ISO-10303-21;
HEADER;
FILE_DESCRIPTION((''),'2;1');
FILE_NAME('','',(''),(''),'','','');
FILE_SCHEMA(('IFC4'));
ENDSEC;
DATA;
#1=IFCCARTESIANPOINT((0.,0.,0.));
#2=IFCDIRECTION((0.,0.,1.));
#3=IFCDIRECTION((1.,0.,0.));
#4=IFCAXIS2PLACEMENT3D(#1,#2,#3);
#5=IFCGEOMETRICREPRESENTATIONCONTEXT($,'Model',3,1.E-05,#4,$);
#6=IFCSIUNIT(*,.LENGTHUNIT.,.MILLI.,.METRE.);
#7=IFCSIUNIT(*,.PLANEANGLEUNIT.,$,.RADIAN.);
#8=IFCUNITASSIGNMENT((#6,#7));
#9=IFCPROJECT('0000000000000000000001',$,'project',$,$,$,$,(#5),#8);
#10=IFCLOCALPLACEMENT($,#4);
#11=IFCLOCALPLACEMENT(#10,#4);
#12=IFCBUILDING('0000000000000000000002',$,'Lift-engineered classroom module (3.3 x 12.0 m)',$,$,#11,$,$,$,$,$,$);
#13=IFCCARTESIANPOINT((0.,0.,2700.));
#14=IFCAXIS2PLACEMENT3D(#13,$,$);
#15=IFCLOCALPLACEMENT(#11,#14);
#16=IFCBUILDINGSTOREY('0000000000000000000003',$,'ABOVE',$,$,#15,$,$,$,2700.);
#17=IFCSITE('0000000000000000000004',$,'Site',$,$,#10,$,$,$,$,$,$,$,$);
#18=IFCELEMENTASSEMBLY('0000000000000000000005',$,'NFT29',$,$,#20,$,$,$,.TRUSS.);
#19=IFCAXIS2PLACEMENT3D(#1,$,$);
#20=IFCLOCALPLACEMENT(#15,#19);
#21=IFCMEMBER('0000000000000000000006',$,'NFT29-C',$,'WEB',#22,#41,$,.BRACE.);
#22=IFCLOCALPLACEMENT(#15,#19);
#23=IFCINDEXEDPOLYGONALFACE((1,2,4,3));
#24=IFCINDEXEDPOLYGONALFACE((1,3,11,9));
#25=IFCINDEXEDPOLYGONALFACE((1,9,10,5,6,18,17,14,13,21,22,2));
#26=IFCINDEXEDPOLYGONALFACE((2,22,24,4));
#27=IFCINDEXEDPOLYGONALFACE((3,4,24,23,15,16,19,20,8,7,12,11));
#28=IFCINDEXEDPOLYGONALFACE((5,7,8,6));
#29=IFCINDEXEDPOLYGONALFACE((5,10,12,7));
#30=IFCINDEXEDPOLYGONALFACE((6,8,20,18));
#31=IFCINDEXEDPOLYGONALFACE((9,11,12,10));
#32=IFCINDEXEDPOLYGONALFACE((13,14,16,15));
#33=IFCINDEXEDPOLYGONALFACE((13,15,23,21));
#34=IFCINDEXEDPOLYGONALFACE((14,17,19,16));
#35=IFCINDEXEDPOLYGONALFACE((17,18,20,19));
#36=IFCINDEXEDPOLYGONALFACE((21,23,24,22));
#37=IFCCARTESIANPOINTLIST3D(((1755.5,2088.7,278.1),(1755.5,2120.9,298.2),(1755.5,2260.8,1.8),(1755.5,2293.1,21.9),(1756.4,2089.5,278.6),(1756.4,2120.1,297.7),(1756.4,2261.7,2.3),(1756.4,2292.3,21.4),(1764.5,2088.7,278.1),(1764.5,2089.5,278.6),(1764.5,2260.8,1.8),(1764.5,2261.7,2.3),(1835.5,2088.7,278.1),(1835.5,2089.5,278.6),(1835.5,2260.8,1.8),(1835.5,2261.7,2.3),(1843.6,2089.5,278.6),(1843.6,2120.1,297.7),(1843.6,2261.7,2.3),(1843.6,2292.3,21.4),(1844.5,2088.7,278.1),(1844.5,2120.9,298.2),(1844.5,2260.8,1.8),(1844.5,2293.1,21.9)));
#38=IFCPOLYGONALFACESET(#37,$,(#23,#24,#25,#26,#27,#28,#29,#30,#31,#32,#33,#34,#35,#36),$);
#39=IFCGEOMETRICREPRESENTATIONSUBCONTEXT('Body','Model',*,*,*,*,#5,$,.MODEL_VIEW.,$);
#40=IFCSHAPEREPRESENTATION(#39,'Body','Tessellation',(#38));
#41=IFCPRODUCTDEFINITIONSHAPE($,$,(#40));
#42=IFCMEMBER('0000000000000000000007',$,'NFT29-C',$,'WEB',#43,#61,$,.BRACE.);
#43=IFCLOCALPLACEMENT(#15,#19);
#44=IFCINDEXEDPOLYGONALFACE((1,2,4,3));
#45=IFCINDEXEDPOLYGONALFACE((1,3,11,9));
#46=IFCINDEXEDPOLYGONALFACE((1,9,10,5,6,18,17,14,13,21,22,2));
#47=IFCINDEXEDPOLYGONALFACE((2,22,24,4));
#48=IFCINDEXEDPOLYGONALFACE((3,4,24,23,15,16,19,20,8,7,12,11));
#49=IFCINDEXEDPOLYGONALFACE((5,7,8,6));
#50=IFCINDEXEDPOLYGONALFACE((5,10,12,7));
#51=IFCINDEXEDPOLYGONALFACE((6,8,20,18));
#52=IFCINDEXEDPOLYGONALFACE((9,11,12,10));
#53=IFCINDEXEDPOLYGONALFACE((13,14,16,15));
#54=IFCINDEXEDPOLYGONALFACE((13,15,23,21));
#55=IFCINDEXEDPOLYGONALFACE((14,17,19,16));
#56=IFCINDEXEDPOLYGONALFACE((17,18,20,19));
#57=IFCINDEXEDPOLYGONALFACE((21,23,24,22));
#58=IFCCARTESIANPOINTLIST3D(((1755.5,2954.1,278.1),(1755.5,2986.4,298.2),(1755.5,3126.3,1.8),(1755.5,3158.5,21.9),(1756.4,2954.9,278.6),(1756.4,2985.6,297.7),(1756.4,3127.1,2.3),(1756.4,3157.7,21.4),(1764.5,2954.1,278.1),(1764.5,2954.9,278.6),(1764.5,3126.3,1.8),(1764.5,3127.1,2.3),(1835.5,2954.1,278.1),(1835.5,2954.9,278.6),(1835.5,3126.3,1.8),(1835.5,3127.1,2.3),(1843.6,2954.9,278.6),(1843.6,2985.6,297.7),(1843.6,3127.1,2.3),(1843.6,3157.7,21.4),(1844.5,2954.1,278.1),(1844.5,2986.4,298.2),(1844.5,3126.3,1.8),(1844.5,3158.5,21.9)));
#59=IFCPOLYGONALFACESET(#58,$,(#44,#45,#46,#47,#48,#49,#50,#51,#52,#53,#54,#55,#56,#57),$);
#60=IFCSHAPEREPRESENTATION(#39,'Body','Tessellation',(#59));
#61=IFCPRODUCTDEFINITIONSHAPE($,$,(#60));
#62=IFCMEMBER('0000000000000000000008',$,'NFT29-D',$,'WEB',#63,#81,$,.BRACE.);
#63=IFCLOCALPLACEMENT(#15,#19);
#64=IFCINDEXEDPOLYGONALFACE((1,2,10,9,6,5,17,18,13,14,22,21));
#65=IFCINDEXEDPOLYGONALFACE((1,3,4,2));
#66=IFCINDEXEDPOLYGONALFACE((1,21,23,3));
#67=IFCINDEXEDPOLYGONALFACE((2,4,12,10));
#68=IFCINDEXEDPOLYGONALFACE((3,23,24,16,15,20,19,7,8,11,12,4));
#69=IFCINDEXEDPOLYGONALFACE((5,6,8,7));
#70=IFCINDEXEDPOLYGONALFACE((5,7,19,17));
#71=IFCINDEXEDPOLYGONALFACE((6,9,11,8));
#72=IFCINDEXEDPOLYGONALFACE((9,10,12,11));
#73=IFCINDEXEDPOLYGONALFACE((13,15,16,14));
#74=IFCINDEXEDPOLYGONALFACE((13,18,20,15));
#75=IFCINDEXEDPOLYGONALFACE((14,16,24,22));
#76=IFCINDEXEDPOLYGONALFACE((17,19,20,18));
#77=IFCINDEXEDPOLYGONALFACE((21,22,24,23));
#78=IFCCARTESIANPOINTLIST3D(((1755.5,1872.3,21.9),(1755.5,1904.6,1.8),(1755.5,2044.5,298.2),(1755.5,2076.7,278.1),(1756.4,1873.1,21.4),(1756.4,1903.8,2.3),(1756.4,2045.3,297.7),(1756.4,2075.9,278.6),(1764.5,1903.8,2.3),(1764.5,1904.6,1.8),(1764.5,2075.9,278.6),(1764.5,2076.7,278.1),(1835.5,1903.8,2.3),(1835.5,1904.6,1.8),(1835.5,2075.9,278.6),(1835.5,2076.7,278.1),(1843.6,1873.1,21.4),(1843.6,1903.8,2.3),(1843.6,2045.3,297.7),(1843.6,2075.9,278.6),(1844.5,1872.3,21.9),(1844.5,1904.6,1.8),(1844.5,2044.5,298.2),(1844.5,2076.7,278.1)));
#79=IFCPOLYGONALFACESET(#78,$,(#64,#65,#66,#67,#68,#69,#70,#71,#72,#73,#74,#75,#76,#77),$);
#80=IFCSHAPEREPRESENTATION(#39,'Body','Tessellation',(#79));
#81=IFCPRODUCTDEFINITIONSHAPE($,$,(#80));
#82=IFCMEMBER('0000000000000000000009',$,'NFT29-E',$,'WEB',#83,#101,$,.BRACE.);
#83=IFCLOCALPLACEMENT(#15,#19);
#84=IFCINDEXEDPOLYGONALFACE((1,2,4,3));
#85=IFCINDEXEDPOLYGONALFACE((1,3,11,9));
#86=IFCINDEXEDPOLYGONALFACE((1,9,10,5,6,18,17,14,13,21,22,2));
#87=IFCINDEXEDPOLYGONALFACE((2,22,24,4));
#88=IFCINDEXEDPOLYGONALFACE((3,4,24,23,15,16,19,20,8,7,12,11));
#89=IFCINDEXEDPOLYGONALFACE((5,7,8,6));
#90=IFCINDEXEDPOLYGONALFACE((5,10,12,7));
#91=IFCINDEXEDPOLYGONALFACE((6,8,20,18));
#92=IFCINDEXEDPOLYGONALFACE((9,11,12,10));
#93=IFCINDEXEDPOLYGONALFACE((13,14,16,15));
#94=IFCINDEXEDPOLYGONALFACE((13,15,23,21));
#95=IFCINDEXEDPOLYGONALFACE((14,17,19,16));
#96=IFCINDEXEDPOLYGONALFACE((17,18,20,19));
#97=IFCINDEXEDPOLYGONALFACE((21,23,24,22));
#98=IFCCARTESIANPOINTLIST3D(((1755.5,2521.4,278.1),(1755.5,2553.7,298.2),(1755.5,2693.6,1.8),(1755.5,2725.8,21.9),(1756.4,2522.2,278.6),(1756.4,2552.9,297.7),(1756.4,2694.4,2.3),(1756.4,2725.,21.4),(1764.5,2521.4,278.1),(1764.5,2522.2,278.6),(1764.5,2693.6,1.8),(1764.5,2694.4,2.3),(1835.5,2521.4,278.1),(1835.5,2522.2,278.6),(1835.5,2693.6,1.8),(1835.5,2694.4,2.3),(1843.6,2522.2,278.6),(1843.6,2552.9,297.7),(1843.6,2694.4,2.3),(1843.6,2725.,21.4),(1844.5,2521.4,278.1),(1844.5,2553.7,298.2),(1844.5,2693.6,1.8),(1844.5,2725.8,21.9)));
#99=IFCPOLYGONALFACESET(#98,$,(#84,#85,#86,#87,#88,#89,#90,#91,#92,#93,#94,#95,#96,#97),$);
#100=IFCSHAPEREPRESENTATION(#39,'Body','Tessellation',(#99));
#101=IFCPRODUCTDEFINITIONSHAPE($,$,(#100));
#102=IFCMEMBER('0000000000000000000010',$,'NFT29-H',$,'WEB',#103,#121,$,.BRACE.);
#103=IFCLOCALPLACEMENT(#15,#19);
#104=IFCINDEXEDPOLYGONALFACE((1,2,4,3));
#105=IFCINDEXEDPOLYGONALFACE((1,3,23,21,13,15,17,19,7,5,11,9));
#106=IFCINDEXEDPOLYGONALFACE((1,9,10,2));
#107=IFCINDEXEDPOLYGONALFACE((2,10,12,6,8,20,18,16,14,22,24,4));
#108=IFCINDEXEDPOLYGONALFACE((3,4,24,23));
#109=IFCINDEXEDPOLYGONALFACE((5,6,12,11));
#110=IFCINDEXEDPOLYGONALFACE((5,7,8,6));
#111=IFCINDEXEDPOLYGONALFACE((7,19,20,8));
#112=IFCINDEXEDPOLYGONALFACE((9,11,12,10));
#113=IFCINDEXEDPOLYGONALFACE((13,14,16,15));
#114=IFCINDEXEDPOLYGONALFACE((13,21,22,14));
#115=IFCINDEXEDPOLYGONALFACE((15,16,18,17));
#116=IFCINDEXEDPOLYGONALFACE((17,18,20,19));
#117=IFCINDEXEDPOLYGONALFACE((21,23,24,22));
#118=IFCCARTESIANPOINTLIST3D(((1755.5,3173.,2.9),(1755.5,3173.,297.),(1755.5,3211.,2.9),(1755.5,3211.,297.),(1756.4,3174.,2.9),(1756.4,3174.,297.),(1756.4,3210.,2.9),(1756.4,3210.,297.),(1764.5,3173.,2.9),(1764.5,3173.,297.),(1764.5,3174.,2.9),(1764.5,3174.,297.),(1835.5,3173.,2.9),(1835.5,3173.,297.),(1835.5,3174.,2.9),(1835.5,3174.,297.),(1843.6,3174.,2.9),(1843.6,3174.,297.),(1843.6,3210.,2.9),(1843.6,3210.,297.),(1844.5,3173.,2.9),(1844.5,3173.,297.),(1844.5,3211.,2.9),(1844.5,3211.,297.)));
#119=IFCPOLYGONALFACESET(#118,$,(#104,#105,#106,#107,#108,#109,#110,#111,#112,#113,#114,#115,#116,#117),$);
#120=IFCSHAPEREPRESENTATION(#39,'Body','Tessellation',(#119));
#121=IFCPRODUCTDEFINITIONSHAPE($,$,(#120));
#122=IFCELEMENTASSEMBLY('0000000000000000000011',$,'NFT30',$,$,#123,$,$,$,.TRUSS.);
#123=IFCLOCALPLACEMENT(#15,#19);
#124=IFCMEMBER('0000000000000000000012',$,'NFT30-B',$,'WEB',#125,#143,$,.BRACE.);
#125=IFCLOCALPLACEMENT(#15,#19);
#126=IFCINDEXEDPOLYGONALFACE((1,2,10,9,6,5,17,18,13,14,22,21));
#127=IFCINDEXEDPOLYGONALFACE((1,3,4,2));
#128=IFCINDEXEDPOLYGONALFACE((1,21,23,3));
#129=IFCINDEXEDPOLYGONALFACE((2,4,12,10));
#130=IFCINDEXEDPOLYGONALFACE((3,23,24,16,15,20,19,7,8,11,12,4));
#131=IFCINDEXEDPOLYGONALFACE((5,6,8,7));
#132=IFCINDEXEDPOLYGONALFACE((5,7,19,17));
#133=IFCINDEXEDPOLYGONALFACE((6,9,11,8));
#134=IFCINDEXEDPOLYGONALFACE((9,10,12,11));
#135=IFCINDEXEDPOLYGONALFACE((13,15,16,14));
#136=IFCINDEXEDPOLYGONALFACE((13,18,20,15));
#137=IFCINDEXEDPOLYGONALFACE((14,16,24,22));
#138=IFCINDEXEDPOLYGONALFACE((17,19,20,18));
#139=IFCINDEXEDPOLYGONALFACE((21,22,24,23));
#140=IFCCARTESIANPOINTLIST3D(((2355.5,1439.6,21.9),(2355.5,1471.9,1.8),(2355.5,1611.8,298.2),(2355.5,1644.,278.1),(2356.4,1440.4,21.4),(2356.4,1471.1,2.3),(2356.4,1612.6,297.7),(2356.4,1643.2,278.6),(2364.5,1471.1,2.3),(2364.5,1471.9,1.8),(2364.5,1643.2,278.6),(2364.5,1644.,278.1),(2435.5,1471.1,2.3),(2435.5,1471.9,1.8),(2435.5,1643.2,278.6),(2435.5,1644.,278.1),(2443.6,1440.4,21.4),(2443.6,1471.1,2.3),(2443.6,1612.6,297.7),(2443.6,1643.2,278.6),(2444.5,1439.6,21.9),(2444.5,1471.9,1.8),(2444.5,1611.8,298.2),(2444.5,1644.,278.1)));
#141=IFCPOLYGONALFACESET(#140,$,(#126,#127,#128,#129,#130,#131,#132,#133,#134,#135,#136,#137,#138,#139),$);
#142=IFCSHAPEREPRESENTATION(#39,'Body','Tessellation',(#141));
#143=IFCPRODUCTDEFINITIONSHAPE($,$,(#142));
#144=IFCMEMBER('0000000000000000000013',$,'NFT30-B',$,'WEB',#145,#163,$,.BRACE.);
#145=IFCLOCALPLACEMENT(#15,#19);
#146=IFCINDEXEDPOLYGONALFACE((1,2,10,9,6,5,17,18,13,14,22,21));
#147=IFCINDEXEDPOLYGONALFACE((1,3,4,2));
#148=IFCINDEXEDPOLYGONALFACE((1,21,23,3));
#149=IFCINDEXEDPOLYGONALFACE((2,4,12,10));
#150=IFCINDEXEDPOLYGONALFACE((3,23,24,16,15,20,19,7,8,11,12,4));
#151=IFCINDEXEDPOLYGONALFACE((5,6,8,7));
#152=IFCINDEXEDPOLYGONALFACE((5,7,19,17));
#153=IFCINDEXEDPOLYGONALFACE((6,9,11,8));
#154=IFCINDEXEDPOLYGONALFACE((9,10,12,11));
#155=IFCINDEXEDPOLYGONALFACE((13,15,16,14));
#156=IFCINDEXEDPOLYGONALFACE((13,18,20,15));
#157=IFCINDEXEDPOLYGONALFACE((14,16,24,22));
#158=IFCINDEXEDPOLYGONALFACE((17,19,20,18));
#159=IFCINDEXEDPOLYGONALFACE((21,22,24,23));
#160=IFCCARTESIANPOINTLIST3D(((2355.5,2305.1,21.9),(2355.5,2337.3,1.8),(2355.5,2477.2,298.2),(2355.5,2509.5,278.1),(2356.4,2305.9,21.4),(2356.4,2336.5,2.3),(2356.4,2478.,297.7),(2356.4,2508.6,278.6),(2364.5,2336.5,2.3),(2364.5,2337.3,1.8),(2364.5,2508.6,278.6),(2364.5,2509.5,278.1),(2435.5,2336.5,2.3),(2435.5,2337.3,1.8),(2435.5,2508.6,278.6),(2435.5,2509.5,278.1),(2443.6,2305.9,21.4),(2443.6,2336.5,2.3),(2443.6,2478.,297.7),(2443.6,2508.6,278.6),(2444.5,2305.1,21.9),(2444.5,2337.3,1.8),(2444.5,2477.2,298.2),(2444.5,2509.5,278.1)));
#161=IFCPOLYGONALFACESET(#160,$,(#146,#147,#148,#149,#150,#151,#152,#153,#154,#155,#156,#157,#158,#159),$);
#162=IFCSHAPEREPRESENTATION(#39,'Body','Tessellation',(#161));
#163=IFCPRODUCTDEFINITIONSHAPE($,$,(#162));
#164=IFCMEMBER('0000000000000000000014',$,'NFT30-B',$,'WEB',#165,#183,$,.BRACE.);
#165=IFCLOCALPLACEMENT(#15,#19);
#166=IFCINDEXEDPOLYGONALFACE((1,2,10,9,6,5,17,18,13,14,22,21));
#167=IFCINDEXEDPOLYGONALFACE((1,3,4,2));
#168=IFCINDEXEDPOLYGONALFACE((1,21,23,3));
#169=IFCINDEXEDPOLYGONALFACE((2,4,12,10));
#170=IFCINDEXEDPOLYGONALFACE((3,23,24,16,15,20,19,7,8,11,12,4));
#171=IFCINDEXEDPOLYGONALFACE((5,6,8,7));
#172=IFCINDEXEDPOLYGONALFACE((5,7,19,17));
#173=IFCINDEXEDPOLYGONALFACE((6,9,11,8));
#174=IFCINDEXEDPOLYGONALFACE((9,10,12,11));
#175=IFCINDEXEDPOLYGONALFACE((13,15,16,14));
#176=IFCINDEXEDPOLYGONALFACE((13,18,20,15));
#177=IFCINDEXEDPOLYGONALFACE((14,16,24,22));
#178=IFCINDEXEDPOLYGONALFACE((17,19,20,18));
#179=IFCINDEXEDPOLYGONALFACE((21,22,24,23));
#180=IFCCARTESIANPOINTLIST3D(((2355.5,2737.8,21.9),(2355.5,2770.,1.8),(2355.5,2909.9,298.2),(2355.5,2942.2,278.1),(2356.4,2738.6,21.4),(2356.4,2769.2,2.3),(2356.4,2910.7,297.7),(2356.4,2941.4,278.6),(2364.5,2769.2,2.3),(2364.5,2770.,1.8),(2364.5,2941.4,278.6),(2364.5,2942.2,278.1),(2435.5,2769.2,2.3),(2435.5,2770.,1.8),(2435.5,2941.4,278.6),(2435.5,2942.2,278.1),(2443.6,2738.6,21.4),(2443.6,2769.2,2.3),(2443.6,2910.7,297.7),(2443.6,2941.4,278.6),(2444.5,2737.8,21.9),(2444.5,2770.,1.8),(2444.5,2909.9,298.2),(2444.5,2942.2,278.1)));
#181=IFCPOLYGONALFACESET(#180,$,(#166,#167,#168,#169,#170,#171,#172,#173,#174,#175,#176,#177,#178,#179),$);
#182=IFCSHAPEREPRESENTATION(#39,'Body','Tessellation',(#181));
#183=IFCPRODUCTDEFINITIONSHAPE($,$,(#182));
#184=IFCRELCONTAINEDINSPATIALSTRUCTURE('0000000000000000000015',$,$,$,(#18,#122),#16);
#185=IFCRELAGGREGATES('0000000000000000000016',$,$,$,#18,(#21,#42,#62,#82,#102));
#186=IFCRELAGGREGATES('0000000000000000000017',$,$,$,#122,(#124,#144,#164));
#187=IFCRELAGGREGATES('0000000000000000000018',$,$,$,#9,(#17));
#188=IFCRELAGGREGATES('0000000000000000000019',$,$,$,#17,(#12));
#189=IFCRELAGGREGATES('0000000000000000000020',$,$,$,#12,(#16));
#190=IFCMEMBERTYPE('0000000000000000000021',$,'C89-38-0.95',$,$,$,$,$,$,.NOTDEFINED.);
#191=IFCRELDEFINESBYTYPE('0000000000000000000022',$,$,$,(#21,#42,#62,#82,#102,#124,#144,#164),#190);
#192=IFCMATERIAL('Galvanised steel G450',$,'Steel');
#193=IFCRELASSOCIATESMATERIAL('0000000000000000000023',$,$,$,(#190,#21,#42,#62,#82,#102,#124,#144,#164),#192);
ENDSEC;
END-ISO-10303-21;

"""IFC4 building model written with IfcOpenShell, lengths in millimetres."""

from ifc_helpers import new_model, si_unit, frame, origin, origin_with_axes, origin_2d, place, context, subcontext, project, spatial, c_section, extrude, material, material_profile, profile_set, profile_usage, type_object, element, aggregate, save


model = new_model("IFC4")

# Units and contexts
model_context = context("Model", 3, precision=1e-05, world=origin_with_axes())
body_context = subcontext(model_context, "Body", "Model", "MODEL_VIEW")
ifc_project = project(units=[si_unit("LENGTHUNIT", "METRE", prefix="MILLI"), si_unit("PLANEANGLEUNIT", "RADIAN")], contexts=[model_context])

# Site, building, storey
site_placement = place(None, origin_with_axes())
site = spatial("IfcSite", under=ifc_project, at=site_placement, Name="Site")
building_placement = place(site_placement, origin_with_axes())
building = spatial("IfcBuilding", under=site, at=building_placement, Name="Lift-engineered classroom module (3.3 x 12.0 m)")
storey_placement = place(building_placement, frame((0.0, 0.0, 2700.0)))
storey = spatial("IfcBuildingStorey", under=building, at=storey_placement, Name="ABOVE", Elevation=2700.0)

# Element assemblies, members
ifc_material = material(Name="Galvanised steel G450", Category="Steel")
ifc_material_profile_1 = material_profile(ifc_material, c_section(Depth=89.0, Width=38.0, WallThickness=0.9, Girth=9.0, at=origin_2d()), Name="C89-38-0.95")
ifc_profile_set_1 = profile_set([ifc_material_profile_1], Name="C89-38-0.95")
ifc_profile_usage_1 = profile_usage(ifc_profile_set_1)
member_type_1 = type_object("IfcMemberType", Name="C89-38-0.95", PredefinedType="NOTDEFINED", material=ifc_profile_set_1)
assembly_1_placement = place(storey_placement, frame((1800.0, 89.0, 0.0)))
assembly_1 = element("IfcElementAssembly", 1, at=assembly_1_placement, inside=storey, Name="NFT29", PredefinedType="TRUSS")
member_1_placement = place(assembly_1_placement, frame((0.0, 2188.0, 11.8), z_axis=(0.0, -0.528797, 0.848748), x_axis=(0.0, -0.848748, -0.528797)))
member_1 = element("IfcMember", 2, at=member_1_placement, type_object=member_type_1, material=ifc_profile_usage_1, Name="NFT29-C", ObjectType="WEB", PredefinedType="BRACE", context=body_context, shape_type="SweptSolid", body=[
    extrude(c_section(Depth=89.0, Width=38.0, WallThickness=0.9, Girth=9.0, at=origin_2d()), origin(), (0.0, 0.0, 1.0), 325.6),
])
member_2_placement = place(assembly_1_placement, frame((0.0, 3053.4, 11.8), z_axis=(0.0, -0.528797, 0.848748), x_axis=(0.0, -0.848748, -0.528797)))
member_2 = element("IfcMember", 3, at=member_2_placement, type_object=member_type_1, material=ifc_profile_usage_1, Name="NFT29-C", ObjectType="WEB", PredefinedType="BRACE", context=body_context, shape_type="SweptSolid", body=[
    extrude(c_section(Depth=89.0, Width=38.0, WallThickness=0.9, Girth=9.0, at=origin_2d()), origin(), (0.0, 0.0, 1.0), 325.6),
])
member_3_placement = place(assembly_1_placement, frame((0.0, 1799.5, 11.8), z_axis=(0.0, 0.528775, 0.848762), x_axis=(0.0, 0.848762, -0.528775)))
member_3 = element("IfcMember", 4, at=member_3_placement, type_object=member_type_1, material=ifc_profile_usage_1, Name="NFT29-D", ObjectType="WEB", PredefinedType="BRACE", context=body_context, shape_type="SweptSolid", body=[
    extrude(c_section(Depth=89.0, Width=38.0, WallThickness=0.9, Girth=9.0, at=origin_2d()), origin(), (0.0, 0.0, 1.0), 325.6),
])
member_4_placement = place(assembly_1_placement, frame((0.0, 2620.7, 11.8), z_axis=(0.0, -0.528775, 0.848762), x_axis=(0.0, -0.848762, -0.528775)))
member_4 = element("IfcMember", 5, at=member_4_placement, type_object=member_type_1, material=ifc_profile_usage_1, Name="NFT29-E", ObjectType="WEB", PredefinedType="BRACE", context=body_context, shape_type="SweptSolid", body=[
    extrude(c_section(Depth=89.0, Width=38.0, WallThickness=0.9, Girth=9.0, at=origin_2d()), origin(), (0.0, 0.0, 1.0), 325.6),
])
member_5_placement = place(assembly_1_placement, frame((0.0, 3103.0, 2.9), z_axis=(0.0, 0.0, 1.0), x_axis=(0.0, -1.0, 0.0)))
member_5 = element("IfcMember", 6, at=member_5_placement, type_object=member_type_1, material=ifc_profile_usage_1, Name="NFT29-H", ObjectType="WEB", PredefinedType="BRACE", context=body_context, shape_type="SweptSolid", body=[
    extrude(c_section(Depth=89.0, Width=38.0, WallThickness=0.9, Girth=9.0, at=origin_2d()), origin(), (0.0, 0.0, 1.0), 294.1),
])
aggregate(assembly_1, [member_1, member_2, member_3, member_4, member_5])
assembly_2_placement = place(storey_placement, frame((2400.0, 89.0, 0.0)))
assembly_2 = element("IfcElementAssembly", 7, at=assembly_2_placement, inside=storey, Name="NFT30", PredefinedType="TRUSS")
member_6_placement = place(assembly_2_placement, frame((0.0, 1366.7, 11.8), z_axis=(0.0, 0.528797, 0.848748), x_axis=(0.0, 0.848748, -0.528797)))
member_6 = element("IfcMember", 8, at=member_6_placement, type_object=member_type_1, material=ifc_profile_usage_1, Name="NFT30-B", ObjectType="WEB", PredefinedType="BRACE", context=body_context, shape_type="SweptSolid", body=[
    extrude(c_section(Depth=89.0, Width=38.0, WallThickness=0.9, Girth=9.0, at=origin_2d()), origin(), (0.0, 0.0, 1.0), 325.6),
])
member_7_placement = place(assembly_2_placement, frame((0.0, 2232.2, 11.8), z_axis=(0.0, 0.528797, 0.848748), x_axis=(0.0, 0.848748, -0.528797)))
member_7 = element("IfcMember", 9, at=member_7_placement, type_object=member_type_1, material=ifc_profile_usage_1, Name="NFT30-B", ObjectType="WEB", PredefinedType="BRACE", context=body_context, shape_type="SweptSolid", body=[
    extrude(c_section(Depth=89.0, Width=38.0, WallThickness=0.9, Girth=9.0, at=origin_2d()), origin(), (0.0, 0.0, 1.0), 325.6),
])
member_8_placement = place(assembly_2_placement, frame((0.0, 2664.9, 11.8), z_axis=(0.0, 0.528797, 0.848748), x_axis=(0.0, 0.848748, -0.528797)))
member_8 = element("IfcMember", 10, at=member_8_placement, type_object=member_type_1, material=ifc_profile_usage_1, Name="NFT30-B", ObjectType="WEB", PredefinedType="BRACE", context=body_context, shape_type="SweptSolid", body=[
    extrude(c_section(Depth=89.0, Width=38.0, WallThickness=0.9, Girth=9.0, at=origin_2d()), origin(), (0.0, 0.0, 1.0), 325.6),
])
aggregate(assembly_2, [member_6, member_7, member_8])

save(model, "model.ifc")
